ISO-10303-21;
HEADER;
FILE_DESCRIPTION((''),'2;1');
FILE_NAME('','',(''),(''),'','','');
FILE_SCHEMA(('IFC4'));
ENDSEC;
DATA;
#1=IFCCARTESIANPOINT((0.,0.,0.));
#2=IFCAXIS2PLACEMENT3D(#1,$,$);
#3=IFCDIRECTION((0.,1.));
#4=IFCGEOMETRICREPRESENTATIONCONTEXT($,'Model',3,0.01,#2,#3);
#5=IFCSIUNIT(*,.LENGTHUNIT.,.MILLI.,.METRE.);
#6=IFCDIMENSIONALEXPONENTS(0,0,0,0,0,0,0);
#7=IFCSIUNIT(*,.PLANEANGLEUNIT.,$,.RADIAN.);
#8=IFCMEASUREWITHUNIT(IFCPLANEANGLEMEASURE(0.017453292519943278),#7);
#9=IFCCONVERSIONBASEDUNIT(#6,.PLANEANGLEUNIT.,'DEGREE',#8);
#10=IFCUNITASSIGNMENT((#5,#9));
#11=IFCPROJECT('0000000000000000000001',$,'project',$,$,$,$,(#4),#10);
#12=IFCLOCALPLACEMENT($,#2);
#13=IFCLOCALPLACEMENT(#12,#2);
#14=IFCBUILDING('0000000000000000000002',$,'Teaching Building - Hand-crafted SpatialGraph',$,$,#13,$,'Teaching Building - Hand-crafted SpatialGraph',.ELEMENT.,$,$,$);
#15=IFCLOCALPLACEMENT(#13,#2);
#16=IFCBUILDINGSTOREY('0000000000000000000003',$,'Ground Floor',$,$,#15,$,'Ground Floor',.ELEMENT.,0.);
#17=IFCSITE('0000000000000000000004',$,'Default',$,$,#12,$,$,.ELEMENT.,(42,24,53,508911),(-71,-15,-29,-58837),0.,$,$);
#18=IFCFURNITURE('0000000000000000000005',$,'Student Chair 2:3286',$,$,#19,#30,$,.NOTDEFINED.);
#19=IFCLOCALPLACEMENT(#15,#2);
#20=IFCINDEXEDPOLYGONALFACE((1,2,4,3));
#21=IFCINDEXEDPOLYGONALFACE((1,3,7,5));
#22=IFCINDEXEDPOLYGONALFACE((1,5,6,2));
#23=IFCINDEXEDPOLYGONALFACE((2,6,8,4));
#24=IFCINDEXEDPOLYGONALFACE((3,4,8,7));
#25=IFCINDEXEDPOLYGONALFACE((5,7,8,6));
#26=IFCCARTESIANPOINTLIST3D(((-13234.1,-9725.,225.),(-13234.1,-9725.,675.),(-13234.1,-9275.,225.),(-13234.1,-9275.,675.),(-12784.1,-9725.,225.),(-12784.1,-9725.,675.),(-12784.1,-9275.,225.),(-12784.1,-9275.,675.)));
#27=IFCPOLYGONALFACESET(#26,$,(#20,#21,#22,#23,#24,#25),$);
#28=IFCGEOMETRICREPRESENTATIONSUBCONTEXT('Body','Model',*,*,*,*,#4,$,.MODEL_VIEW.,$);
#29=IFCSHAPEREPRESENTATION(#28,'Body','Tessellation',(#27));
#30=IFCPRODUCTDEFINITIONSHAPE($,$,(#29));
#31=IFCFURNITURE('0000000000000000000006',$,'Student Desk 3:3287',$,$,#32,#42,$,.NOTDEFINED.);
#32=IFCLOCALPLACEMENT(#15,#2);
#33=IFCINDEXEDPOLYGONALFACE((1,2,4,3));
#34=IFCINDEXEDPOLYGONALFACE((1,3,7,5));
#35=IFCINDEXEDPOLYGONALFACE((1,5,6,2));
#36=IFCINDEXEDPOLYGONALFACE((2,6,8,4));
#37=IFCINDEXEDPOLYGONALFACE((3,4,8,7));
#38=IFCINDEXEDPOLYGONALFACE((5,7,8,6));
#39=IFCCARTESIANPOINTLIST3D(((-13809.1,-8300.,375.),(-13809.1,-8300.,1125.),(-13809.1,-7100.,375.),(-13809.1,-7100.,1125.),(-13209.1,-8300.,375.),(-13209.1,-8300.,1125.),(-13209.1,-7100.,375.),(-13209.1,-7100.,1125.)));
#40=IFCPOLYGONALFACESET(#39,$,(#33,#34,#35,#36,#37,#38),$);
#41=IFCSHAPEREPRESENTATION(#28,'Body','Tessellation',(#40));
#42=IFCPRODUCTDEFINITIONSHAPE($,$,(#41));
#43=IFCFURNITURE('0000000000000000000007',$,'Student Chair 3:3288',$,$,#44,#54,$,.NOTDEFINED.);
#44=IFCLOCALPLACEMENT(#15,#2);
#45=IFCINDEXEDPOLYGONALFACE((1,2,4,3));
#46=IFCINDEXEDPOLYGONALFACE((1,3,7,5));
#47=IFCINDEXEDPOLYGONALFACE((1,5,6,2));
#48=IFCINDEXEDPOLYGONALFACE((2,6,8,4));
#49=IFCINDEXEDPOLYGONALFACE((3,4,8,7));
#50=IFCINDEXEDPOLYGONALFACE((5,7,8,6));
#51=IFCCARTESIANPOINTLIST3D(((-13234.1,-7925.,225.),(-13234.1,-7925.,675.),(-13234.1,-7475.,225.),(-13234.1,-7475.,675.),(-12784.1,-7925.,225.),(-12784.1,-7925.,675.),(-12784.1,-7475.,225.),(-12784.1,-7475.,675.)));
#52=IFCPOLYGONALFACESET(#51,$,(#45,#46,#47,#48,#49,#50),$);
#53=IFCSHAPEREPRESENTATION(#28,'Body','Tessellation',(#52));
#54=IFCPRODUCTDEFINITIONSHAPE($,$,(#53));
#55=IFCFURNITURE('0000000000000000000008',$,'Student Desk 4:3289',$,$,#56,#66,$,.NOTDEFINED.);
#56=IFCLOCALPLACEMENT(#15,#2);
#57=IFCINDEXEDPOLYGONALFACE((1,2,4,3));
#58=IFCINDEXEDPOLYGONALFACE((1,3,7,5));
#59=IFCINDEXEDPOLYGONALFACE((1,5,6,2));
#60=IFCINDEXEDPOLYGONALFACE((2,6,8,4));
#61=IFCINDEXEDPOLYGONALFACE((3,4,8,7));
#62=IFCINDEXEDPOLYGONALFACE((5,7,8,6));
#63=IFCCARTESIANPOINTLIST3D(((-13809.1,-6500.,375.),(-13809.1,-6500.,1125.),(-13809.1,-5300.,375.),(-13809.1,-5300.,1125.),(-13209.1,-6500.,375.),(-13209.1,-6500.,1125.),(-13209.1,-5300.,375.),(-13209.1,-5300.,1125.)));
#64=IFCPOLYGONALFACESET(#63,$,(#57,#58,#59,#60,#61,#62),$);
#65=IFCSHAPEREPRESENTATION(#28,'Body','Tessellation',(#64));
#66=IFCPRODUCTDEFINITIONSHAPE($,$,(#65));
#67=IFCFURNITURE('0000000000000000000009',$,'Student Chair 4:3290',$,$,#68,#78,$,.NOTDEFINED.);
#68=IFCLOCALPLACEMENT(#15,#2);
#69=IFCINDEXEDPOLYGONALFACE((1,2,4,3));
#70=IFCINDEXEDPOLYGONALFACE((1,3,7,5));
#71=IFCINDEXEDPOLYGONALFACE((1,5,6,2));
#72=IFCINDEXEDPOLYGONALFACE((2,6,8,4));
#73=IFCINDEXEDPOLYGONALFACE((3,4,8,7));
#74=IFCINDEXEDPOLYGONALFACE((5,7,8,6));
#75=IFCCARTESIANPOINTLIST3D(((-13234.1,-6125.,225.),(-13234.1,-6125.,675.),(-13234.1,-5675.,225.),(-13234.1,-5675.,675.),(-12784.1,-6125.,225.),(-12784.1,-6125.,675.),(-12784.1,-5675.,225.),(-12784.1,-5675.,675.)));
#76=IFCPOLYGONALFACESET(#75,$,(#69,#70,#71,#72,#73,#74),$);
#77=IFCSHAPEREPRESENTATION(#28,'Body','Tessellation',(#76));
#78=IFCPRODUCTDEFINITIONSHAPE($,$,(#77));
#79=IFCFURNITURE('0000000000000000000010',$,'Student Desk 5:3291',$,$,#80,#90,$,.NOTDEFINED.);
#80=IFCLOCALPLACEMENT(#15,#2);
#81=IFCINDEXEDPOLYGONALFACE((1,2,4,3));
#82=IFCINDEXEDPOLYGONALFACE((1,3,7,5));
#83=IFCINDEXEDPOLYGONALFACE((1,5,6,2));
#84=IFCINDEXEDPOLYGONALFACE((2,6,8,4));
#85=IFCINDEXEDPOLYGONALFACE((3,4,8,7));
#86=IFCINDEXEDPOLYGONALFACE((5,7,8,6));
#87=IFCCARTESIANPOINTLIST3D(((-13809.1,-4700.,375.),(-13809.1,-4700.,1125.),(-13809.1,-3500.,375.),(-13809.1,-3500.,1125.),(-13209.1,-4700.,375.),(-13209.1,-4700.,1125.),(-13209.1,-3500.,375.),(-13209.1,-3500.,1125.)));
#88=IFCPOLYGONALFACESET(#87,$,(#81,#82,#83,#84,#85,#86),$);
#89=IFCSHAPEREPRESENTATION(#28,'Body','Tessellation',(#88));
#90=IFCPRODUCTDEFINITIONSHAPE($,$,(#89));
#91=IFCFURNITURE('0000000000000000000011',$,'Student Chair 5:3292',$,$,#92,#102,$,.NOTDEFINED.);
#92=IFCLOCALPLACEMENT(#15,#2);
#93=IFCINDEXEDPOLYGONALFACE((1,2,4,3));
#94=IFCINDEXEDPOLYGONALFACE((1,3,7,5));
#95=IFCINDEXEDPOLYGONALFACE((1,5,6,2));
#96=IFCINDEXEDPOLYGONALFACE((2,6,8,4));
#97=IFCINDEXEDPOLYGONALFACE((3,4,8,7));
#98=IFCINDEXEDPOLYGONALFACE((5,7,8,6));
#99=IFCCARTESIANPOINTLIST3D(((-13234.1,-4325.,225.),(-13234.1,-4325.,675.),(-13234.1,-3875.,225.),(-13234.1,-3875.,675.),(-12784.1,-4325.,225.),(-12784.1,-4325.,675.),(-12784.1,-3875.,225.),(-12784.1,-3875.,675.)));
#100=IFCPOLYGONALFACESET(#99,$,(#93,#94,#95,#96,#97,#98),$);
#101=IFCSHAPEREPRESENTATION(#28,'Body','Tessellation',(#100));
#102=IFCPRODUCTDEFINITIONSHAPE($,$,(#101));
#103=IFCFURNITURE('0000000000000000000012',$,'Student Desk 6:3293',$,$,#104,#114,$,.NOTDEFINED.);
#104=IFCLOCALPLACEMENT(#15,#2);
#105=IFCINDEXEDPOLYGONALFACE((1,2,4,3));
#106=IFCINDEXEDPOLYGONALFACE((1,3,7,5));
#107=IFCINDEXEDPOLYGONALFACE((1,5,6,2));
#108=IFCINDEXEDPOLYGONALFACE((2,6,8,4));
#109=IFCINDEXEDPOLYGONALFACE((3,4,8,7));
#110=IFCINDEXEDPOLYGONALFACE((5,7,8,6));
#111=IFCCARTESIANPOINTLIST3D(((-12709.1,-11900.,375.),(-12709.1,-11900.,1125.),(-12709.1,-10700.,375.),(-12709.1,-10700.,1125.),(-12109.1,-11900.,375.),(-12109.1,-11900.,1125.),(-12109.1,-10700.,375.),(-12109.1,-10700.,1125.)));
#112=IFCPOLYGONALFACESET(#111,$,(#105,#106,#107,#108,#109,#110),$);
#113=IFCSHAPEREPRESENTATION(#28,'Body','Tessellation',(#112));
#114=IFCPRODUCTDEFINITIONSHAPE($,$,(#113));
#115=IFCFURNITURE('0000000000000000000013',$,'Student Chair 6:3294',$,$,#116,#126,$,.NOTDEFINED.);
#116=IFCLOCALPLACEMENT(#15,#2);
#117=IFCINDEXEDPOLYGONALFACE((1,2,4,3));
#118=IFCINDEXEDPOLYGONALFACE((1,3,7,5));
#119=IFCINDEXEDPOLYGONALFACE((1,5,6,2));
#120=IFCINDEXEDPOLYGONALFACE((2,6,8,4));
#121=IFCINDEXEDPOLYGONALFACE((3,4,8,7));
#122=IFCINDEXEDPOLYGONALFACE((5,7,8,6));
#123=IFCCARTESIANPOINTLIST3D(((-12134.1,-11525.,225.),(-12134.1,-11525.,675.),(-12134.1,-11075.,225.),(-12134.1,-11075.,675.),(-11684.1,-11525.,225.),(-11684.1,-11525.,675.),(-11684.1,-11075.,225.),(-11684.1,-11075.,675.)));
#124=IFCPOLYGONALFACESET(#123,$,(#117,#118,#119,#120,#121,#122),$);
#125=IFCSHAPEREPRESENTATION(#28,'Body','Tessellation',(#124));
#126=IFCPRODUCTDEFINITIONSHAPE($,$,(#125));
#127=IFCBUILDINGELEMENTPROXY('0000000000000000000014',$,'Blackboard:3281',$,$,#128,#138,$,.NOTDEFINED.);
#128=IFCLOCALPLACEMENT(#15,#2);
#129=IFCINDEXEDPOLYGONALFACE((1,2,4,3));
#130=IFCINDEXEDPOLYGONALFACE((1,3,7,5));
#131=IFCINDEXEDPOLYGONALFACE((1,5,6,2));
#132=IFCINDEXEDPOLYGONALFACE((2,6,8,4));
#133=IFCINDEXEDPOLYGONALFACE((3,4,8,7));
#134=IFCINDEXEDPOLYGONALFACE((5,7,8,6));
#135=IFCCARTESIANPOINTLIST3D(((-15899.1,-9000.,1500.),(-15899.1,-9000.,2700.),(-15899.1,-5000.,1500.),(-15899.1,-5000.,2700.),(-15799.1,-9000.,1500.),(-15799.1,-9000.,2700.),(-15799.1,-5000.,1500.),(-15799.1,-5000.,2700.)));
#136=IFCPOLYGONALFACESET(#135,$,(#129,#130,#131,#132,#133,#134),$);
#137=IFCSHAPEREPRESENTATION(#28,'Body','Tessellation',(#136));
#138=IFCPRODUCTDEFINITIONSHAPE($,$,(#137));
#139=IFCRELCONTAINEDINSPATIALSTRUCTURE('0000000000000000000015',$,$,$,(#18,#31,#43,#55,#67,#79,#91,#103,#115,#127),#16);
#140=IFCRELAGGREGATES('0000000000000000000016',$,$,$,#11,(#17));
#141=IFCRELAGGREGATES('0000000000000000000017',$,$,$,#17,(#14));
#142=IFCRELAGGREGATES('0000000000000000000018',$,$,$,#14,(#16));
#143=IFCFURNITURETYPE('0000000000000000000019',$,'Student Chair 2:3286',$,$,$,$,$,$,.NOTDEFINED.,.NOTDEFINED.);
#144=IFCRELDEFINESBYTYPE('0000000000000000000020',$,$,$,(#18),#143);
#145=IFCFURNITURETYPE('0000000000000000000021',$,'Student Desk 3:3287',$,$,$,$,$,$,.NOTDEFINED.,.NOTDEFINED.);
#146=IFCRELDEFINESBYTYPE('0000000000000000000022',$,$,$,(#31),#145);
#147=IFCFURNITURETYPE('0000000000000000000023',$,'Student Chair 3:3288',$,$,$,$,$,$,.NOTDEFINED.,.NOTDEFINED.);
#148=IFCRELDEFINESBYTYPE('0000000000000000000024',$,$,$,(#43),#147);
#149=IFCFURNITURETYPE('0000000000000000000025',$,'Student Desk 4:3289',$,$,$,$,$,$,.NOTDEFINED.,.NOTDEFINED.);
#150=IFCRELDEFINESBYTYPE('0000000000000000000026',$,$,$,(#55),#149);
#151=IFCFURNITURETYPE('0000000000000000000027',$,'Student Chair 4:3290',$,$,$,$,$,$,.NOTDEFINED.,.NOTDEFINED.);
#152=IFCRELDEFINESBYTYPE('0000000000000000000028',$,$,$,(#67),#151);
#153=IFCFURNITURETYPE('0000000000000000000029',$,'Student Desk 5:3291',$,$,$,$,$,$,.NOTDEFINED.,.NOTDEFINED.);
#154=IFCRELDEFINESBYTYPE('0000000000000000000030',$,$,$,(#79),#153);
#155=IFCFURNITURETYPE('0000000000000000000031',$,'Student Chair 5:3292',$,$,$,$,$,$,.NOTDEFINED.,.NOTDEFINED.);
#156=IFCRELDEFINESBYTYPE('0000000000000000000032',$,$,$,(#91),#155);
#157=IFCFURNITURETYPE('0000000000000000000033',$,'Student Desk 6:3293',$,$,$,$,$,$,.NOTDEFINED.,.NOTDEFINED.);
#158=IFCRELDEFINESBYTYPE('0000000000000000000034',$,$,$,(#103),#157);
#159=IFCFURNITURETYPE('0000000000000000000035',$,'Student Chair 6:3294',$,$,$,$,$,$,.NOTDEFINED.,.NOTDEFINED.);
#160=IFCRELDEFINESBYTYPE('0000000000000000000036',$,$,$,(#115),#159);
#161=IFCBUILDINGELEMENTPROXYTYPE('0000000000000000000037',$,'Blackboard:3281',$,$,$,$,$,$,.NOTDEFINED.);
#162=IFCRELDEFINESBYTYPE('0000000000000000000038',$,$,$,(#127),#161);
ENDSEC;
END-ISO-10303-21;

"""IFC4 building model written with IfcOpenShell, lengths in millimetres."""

from ifc_helpers import new_model, entity, si_unit, converted_unit, direction, frame, frame_2d, origin, origin_2d_with_axis, place, context, subcontext, project, spatial, rectangle, extrude, type_object, element, save


model = new_model("IFC4")

# Units and contexts
model_context = context("Model", 3, precision=0.01, world=origin(), true_north=direction((0.0, 1.0)))
body_context = subcontext(model_context, "Body", "Model", "MODEL_VIEW")
ifc_project = project(units=[si_unit("LENGTHUNIT", "METRE", prefix="MILLI"), converted_unit("PLANEANGLEUNIT", "DEGREE", entity("IfcPlaneAngleMeasure", 0.017453292519943278), si_unit("PLANEANGLEUNIT", "RADIAN"), dimensions=[0, 0, 0, 0, 0, 0, 0])], contexts=[model_context])

# Site, building, storey
site_placement = place(None, origin())
site = spatial("IfcSite", under=ifc_project, at=site_placement, Name="Default", CompositionType="ELEMENT", RefLatitude=(42, 24, 53, 508911), RefLongitude=(-71, -15, -29, -58837), RefElevation=0.0)
building_placement = place(site_placement, origin())
building = spatial("IfcBuilding", under=site, at=building_placement, Name="Teaching Building - Hand-crafted SpatialGraph", LongName="Teaching Building - Hand-crafted SpatialGraph", CompositionType="ELEMENT")
storey_placement = place(building_placement, origin())
storey = spatial("IfcBuildingStorey", under=building, at=storey_placement, Name="Ground Floor", LongName="Ground Floor", CompositionType="ELEMENT", Elevation=0.0)

# Furniture
furniture_type_1 = type_object("IfcFurnitureType", Name="Student Chair 2:3286", PredefinedType="NOTDEFINED")
furniture_1_placement = place(storey_placement, origin())
element("IfcFurniture", 1, at=furniture_1_placement, inside=storey, type_object=furniture_type_1, Name="Student Chair 2:3286", PredefinedType="NOTDEFINED", context=body_context, shape_type="SweptSolid", body=[
    extrude(rectangle(XDim=450.0, YDim=450.0, at=origin_2d_with_axis()), frame((-13009.1, -9500.0, 225.0)), (0.0, 0.0, 1.0), 450.0),
])
furniture_type_2 = type_object("IfcFurnitureType", Name="Student Desk 3:3287", PredefinedType="NOTDEFINED")
furniture_2_placement = place(storey_placement, origin())
element("IfcFurniture", 2, at=furniture_2_placement, inside=storey, type_object=furniture_type_2, Name="Student Desk 3:3287", PredefinedType="NOTDEFINED", context=body_context, shape_type="SweptSolid", body=[
    extrude(rectangle(XDim=1200.0, YDim=600.0, at=origin_2d_with_axis()), frame((-13509.1, -7700.0, 375.0), z_axis=(0.0, 0.0, 1.0), x_axis=(0.0, 1.0, 0.0)), (0.0, 0.0, 1.0), 750.0),
])
furniture_type_3 = type_object("IfcFurnitureType", Name="Student Chair 3:3288", PredefinedType="NOTDEFINED")
furniture_3_placement = place(storey_placement, origin())
element("IfcFurniture", 3, at=furniture_3_placement, inside=storey, type_object=furniture_type_3, Name="Student Chair 3:3288", PredefinedType="NOTDEFINED", context=body_context, shape_type="SweptSolid", body=[
    extrude(rectangle(XDim=450.0, YDim=450.0, at=frame_2d((0.0, 0.0), x_axis=(1.0, 0.0))), frame((-13009.1, -7700.0, 225.0)), (0.0, 0.0, 1.0), 450.0),
])
furniture_type_4 = type_object("IfcFurnitureType", Name="Student Desk 4:3289", PredefinedType="NOTDEFINED")
furniture_4_placement = place(storey_placement, origin())
element("IfcFurniture", 4, at=furniture_4_placement, inside=storey, type_object=furniture_type_4, Name="Student Desk 4:3289", PredefinedType="NOTDEFINED", context=body_context, shape_type="SweptSolid", body=[
    extrude(rectangle(XDim=1200.0, YDim=600.0, at=origin_2d_with_axis()), frame((-13509.1, -5900.0, 375.0), z_axis=(0.0, 0.0, 1.0), x_axis=(0.0, 1.0, 0.0)), (0.0, 0.0, 1.0), 750.0),
])
furniture_type_5 = type_object("IfcFurnitureType", Name="Student Chair 4:3290", PredefinedType="NOTDEFINED")
furniture_5_placement = place(storey_placement, origin())
element("IfcFurniture", 5, at=furniture_5_placement, inside=storey, type_object=furniture_type_5, Name="Student Chair 4:3290", PredefinedType="NOTDEFINED", context=body_context, shape_type="SweptSolid", body=[
    extrude(rectangle(XDim=450.0, YDim=450.0, at=origin_2d_with_axis()), frame((-13009.1, -5900.0, 225.0)), (0.0, 0.0, 1.0), 450.0),
])
furniture_type_6 = type_object("IfcFurnitureType", Name="Student Desk 5:3291", PredefinedType="NOTDEFINED")
furniture_6_placement = place(storey_placement, origin())
element("IfcFurniture", 6, at=furniture_6_placement, inside=storey, type_object=furniture_type_6, Name="Student Desk 5:3291", PredefinedType="NOTDEFINED", context=body_context, shape_type="SweptSolid", body=[
    extrude(rectangle(XDim=1200.0, YDim=600.0, at=origin_2d_with_axis()), frame((-13509.1, -4100.0, 375.0), z_axis=(0.0, 0.0, 1.0), x_axis=(0.0, 1.0, 0.0)), (0.0, 0.0, 1.0), 750.0),
])
furniture_type_7 = type_object("IfcFurnitureType", Name="Student Chair 5:3292", PredefinedType="NOTDEFINED")
furniture_7_placement = place(storey_placement, origin())
element("IfcFurniture", 7, at=furniture_7_placement, inside=storey, type_object=furniture_type_7, Name="Student Chair 5:3292", PredefinedType="NOTDEFINED", context=body_context, shape_type="SweptSolid", body=[
    extrude(rectangle(XDim=450.0, YDim=450.0, at=origin_2d_with_axis()), frame((-13009.1, -4100.0, 225.0)), (0.0, 0.0, 1.0), 450.0),
])
furniture_type_8 = type_object("IfcFurnitureType", Name="Student Desk 6:3293", PredefinedType="NOTDEFINED")
furniture_8_placement = place(storey_placement, origin())
element("IfcFurniture", 8, at=furniture_8_placement, inside=storey, type_object=furniture_type_8, Name="Student Desk 6:3293", PredefinedType="NOTDEFINED", context=body_context, shape_type="SweptSolid", body=[
    extrude(rectangle(XDim=1200.0, YDim=600.0, at=origin_2d_with_axis()), frame((-12409.1, -11300.0, 375.0), z_axis=(0.0, 0.0, 1.0), x_axis=(0.0, 1.0, 0.0)), (0.0, 0.0, 1.0), 750.0),
])
furniture_type_9 = type_object("IfcFurnitureType", Name="Student Chair 6:3294", PredefinedType="NOTDEFINED")
furniture_9_placement = place(storey_placement, origin())
element("IfcFurniture", 9, at=furniture_9_placement, inside=storey, type_object=furniture_type_9, Name="Student Chair 6:3294", PredefinedType="NOTDEFINED", context=body_context, shape_type="SweptSolid", body=[
    extrude(rectangle(XDim=450.0, YDim=450.0, at=origin_2d_with_axis()), frame((-11909.1, -11300.0, 225.0)), (0.0, 0.0, 1.0), 450.0),
])

# Building element proxy
building_element_proxy_type = type_object("IfcBuildingElementProxyType", Name="Blackboard:3281", PredefinedType="NOTDEFINED")
proxy_placement = place(storey_placement, origin())
element("IfcBuildingElementProxy", 10, at=proxy_placement, inside=storey, type_object=building_element_proxy_type, Name="Blackboard:3281", PredefinedType="NOTDEFINED", context=body_context, shape_type="SweptSolid", body=[
    extrude(rectangle(XDim=100.0, YDim=4000.0, at=origin_2d_with_axis()), frame((-15849.1, -7000.0, 1500.0)), (0.0, 0.0, 1.0), 1200.0),
])

save(model, "model.ifc")
